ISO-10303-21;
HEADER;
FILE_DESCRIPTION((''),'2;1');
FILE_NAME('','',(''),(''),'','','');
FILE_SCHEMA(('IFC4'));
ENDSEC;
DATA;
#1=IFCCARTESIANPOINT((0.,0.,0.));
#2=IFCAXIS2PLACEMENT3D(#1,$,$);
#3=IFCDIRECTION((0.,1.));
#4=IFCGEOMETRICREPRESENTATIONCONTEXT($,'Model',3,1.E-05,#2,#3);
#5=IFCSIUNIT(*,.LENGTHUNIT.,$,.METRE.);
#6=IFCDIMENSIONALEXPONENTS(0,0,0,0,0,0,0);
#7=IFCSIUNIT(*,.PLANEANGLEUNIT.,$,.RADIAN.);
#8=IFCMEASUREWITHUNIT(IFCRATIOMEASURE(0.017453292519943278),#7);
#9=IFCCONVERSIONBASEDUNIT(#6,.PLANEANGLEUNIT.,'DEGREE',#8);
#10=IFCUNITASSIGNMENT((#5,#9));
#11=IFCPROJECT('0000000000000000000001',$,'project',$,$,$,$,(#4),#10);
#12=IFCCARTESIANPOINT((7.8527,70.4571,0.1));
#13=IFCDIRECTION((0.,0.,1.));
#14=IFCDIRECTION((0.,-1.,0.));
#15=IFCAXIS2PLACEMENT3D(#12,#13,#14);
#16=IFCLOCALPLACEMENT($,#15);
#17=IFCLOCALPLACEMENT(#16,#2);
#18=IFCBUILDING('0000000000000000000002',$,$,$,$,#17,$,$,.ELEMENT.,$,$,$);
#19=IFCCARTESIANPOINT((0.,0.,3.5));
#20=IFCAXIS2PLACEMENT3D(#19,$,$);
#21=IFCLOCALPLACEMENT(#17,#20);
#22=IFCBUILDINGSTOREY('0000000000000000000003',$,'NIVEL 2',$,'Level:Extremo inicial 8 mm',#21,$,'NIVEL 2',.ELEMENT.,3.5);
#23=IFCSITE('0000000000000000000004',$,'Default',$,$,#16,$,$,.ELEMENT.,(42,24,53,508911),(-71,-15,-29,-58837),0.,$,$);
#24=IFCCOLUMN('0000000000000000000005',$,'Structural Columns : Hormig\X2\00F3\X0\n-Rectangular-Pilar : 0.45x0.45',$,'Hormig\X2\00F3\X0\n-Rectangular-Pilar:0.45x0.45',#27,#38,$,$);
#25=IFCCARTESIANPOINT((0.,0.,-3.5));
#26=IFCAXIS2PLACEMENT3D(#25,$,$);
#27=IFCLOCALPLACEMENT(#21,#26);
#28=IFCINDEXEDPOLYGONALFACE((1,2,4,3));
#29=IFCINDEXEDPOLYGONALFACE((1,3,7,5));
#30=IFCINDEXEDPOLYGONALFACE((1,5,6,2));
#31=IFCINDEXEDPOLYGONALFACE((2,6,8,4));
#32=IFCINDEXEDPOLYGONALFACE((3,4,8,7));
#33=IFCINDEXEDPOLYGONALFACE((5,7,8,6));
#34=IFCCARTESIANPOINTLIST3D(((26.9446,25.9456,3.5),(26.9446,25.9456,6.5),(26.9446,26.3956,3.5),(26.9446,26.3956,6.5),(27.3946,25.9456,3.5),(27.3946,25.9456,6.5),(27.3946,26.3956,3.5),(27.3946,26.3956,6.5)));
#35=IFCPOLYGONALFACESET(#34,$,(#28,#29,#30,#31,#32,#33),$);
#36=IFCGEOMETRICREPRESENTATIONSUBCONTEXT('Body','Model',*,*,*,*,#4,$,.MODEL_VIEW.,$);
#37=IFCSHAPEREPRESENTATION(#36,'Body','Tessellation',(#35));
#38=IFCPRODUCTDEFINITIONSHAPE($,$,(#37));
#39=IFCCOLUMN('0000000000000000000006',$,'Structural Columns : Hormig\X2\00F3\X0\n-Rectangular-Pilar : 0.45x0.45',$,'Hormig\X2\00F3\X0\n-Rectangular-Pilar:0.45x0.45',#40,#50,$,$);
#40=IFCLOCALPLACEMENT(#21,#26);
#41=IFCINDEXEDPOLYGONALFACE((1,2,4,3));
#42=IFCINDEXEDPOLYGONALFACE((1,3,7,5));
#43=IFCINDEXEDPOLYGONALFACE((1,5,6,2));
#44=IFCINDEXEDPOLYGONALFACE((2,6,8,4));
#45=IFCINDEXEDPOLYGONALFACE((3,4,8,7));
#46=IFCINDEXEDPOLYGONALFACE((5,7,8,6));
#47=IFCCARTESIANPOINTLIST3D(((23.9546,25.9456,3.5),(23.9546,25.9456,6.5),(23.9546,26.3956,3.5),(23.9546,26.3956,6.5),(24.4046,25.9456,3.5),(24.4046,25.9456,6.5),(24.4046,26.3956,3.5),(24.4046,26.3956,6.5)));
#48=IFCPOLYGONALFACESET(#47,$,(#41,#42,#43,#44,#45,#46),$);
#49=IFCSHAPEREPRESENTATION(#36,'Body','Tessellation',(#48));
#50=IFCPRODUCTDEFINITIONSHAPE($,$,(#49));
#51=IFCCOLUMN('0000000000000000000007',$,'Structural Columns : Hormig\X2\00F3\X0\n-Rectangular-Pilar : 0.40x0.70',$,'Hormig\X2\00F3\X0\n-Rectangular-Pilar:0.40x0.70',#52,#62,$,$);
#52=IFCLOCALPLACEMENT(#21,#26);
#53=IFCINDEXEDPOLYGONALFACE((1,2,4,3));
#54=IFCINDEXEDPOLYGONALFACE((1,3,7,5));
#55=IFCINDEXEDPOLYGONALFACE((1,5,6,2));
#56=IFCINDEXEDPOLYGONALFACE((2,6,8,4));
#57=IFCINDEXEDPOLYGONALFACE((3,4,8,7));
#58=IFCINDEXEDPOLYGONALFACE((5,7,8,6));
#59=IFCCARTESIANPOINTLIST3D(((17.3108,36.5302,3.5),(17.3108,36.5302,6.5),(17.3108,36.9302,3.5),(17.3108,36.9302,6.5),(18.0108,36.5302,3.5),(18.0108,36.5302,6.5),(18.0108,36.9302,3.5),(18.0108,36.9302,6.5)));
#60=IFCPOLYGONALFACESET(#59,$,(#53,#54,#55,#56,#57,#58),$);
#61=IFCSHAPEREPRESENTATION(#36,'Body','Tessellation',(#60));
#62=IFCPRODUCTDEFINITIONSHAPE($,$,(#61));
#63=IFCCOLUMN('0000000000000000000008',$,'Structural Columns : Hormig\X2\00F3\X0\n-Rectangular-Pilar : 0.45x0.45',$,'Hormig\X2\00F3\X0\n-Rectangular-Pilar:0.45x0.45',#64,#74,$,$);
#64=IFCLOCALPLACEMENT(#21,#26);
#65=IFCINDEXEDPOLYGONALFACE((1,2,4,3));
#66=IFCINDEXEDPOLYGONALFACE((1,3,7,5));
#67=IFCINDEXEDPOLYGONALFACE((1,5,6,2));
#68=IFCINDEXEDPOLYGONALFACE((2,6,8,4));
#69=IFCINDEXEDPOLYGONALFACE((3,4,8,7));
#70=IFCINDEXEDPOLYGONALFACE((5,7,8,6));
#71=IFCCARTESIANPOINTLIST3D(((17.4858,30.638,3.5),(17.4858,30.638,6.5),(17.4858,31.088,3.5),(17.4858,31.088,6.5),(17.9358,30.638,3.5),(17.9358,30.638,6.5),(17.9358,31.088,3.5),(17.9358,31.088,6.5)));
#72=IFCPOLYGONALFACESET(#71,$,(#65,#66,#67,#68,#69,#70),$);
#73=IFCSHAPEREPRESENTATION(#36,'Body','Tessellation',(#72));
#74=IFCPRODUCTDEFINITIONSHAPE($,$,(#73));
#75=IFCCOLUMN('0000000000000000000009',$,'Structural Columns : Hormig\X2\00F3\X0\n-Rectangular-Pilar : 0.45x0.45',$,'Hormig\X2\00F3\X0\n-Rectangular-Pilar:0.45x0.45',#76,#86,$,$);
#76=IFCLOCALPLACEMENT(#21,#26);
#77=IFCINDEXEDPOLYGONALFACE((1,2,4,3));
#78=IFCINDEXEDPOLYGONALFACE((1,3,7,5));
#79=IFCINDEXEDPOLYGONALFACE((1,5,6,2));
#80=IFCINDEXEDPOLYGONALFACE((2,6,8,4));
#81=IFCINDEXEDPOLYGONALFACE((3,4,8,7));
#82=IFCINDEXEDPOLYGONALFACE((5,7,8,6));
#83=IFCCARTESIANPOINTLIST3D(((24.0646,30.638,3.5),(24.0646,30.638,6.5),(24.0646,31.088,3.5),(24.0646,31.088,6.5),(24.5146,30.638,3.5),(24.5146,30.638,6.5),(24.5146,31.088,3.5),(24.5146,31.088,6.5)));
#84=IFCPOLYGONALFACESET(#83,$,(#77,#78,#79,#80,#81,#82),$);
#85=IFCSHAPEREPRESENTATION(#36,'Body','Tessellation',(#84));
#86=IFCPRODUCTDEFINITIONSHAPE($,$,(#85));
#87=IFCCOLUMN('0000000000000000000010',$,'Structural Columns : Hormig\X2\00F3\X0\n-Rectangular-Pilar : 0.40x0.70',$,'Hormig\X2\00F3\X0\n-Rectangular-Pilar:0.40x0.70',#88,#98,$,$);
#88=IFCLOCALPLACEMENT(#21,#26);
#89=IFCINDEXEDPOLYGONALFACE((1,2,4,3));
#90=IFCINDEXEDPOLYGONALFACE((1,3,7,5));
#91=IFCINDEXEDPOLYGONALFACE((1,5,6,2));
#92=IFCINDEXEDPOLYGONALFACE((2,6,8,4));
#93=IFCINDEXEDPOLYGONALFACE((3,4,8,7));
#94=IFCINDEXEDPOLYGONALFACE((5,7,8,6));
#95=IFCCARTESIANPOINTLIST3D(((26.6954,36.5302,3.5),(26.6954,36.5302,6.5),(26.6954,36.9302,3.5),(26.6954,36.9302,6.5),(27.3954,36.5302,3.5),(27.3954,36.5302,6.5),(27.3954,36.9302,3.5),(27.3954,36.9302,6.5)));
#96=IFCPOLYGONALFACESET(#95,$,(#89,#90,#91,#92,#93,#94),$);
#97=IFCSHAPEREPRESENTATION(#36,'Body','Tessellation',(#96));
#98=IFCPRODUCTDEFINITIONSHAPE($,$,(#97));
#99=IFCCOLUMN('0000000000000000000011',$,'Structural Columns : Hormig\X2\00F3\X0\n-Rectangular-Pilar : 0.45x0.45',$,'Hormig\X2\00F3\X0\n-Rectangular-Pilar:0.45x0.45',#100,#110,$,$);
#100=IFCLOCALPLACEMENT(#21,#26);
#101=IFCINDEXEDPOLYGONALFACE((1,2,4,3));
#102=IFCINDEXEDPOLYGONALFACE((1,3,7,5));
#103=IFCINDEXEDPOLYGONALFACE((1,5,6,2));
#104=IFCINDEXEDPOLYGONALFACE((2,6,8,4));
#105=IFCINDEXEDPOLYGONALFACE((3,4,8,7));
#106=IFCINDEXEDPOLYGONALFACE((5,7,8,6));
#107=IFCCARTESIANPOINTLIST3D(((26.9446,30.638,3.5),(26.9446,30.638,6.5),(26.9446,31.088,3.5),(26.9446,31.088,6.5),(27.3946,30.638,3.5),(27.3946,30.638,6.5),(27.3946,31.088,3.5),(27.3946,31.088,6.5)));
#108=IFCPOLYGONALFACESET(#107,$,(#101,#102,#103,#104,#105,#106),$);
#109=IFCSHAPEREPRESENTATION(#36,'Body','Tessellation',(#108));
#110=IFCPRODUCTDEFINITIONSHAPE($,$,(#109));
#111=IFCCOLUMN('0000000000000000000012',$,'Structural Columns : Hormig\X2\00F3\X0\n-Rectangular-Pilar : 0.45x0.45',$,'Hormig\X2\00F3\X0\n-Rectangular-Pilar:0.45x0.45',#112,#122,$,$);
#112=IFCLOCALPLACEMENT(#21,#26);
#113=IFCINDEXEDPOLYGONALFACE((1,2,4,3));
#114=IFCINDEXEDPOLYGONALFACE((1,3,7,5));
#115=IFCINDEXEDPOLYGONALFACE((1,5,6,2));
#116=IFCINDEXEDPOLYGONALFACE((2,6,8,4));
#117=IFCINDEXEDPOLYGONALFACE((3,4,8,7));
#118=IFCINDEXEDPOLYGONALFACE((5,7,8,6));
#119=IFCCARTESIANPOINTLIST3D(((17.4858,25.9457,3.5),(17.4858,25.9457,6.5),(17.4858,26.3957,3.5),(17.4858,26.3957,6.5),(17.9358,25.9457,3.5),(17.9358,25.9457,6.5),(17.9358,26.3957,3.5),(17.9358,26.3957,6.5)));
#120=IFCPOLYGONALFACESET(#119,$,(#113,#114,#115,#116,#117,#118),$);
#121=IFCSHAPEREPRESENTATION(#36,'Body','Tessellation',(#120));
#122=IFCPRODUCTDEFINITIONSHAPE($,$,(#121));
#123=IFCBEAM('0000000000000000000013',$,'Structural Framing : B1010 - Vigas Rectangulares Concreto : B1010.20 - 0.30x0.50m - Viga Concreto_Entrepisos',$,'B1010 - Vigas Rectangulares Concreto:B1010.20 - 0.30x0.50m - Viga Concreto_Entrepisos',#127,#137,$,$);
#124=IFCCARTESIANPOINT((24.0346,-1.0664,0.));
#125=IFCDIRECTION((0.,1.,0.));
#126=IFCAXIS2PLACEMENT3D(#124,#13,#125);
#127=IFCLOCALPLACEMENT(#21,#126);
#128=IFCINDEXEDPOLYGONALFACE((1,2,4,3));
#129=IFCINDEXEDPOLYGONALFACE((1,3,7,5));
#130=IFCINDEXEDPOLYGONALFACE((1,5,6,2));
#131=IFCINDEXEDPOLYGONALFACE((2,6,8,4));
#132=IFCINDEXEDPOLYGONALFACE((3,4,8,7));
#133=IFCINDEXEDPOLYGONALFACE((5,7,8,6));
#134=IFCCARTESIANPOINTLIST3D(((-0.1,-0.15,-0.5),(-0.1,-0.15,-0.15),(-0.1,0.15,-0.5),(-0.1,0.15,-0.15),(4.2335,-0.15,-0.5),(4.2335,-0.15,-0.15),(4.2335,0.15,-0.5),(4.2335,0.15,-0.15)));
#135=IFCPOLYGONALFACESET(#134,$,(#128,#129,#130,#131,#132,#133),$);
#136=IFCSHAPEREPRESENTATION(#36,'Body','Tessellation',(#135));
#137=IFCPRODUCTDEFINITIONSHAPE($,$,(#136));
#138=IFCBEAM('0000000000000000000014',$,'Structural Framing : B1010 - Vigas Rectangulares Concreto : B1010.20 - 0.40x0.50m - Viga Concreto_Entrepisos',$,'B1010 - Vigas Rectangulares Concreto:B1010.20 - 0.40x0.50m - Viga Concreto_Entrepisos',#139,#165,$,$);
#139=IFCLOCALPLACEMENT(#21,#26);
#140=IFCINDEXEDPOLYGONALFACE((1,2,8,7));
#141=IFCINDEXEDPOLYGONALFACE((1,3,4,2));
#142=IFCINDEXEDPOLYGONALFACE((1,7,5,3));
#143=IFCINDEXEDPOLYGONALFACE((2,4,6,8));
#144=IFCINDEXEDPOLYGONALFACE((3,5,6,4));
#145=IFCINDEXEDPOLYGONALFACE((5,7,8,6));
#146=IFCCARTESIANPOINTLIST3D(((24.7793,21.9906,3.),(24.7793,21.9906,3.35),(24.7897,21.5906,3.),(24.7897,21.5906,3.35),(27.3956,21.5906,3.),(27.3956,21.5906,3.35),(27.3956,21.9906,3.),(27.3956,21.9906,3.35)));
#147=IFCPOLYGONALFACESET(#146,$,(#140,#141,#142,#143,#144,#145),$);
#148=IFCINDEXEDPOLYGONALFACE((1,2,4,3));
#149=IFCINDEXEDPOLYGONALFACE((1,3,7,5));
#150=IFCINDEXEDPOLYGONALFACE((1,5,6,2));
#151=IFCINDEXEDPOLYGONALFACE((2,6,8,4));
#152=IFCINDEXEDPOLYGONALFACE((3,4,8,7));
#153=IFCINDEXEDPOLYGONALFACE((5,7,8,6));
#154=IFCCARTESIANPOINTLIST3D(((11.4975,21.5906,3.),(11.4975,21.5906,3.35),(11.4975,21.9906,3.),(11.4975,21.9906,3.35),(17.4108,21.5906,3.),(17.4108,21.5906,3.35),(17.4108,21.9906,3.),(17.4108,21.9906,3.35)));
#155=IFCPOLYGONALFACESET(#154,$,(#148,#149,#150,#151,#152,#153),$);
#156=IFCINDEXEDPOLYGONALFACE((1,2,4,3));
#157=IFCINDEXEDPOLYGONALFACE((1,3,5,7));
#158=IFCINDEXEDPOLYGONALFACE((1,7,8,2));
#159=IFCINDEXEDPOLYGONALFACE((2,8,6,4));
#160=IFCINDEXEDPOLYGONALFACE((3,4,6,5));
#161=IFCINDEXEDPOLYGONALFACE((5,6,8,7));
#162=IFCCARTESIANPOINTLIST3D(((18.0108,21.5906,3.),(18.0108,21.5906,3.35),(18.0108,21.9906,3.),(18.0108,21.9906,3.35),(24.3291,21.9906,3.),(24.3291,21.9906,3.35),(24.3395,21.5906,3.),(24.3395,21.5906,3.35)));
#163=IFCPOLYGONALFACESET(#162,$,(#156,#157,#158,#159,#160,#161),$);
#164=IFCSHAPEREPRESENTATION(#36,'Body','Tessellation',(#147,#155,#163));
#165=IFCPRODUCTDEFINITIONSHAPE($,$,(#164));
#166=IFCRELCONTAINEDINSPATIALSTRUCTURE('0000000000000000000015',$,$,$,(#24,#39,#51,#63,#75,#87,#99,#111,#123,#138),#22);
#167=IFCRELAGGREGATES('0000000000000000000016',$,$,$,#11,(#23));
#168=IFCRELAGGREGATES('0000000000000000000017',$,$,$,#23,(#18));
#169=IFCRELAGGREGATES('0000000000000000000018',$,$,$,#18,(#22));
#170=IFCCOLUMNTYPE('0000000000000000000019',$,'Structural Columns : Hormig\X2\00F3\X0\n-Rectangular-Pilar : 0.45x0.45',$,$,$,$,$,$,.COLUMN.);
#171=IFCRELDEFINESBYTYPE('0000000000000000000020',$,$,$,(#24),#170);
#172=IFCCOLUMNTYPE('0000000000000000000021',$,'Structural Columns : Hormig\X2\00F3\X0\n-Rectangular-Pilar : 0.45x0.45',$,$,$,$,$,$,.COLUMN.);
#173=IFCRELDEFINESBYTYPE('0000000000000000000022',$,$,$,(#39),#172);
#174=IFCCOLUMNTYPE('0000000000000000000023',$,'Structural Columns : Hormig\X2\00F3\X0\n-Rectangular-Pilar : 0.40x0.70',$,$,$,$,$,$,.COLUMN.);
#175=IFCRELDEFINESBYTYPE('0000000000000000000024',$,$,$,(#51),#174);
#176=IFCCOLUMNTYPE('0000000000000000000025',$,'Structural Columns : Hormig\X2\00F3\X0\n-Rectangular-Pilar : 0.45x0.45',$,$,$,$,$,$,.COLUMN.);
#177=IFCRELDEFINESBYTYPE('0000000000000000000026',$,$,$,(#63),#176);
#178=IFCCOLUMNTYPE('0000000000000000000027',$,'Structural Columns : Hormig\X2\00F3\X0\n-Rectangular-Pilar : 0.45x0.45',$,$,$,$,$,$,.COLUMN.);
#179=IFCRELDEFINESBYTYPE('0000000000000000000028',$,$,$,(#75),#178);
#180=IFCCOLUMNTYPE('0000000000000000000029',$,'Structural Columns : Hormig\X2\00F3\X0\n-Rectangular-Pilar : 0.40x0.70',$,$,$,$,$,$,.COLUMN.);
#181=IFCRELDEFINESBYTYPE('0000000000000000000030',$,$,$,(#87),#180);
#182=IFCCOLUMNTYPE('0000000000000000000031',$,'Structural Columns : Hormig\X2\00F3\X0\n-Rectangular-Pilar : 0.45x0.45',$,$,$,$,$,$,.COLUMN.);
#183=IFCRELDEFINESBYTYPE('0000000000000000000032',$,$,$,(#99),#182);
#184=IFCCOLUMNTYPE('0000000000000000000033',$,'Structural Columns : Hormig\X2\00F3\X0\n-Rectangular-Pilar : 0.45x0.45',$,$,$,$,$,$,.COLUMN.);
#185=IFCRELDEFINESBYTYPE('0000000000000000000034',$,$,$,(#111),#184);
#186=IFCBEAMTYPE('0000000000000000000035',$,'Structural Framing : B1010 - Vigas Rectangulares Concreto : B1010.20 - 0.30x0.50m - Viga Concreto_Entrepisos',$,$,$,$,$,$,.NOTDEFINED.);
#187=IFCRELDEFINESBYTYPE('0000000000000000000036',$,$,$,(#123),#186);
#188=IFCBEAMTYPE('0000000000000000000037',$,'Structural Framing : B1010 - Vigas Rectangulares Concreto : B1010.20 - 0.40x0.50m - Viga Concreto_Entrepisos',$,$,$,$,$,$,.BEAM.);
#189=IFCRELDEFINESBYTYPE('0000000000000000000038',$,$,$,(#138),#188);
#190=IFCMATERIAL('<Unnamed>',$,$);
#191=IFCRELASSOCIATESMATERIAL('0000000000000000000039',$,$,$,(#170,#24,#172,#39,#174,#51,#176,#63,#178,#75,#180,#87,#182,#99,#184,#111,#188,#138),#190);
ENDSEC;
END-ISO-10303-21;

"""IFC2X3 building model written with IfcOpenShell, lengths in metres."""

from ifc_helpers import new_model, entity, si_unit, converted_unit, direction, frame, frame_2d, origin, origin_2d_with_axis, place, context, subcontext, project, spatial, rectangle, extrude, clip, halfspace, source, transform, mapped, material, type_object, type_shapes, element, save


model = new_model("IFC2X3")

# Units and contexts
model_context = context("Model", 3, precision=1e-05, world=origin(), true_north=direction((0.0, 1.0)))
body_context = subcontext(model_context, "Body", "Model", "MODEL_VIEW")
ifc_project = project(units=[si_unit("LENGTHUNIT", "METRE"), converted_unit("PLANEANGLEUNIT", "DEGREE", entity("IfcRatioMeasure", 0.017453292519943278), si_unit("PLANEANGLEUNIT", "RADIAN"), dimensions=[0, 0, 0, 0, 0, 0, 0])], contexts=[model_context])

# Site, building, storey
site_placement = place(None, frame((7.8527, 70.4571, 0.1), z_axis=(0.0, 0.0, 1.0), x_axis=(0.0, -1.0, 0.0)))
site = spatial("IfcSite", under=ifc_project, at=site_placement, Name="Default", CompositionType="ELEMENT", RefLatitude=(42, 24, 53, 508911), RefLongitude=(-71, -15, -29, -58837), RefElevation=0.0)
building_placement = place(site_placement, origin())
building = spatial("IfcBuilding", under=site, at=building_placement, CompositionType="ELEMENT")
storey_placement = place(building_placement, frame((0.0, 0.0, 3.5)))
storey = spatial("IfcBuildingStorey", under=building, at=storey_placement, Name="NIVEL 2", ObjectType="Level:Extremo inicial 8 mm", LongName="NIVEL 2", CompositionType="ELEMENT", Elevation=3.5)

# Columns
ifc_material_1 = material(Name="<Unnamed>")
column_type_1 = type_object("IfcColumnType", Name="Structural Columns : Hormigón-Rectangular-Pilar : 0.45x0.45", PredefinedType="COLUMN", material=ifc_material_1)
shared_shape_1 = source(origin(), body_context, "Body", "SweptSolid", [
    extrude(rectangle(XDim=0.45, YDim=0.45, at=origin_2d_with_axis()), frame((27.1696, 26.1706, 3.5), z_axis=(0.0, 0.0, 1.0), x_axis=(0.0, -1.0, 0.0)), (0.0, 0.0, 1.0), 3.0),
])
type_shapes(column_type_1, [shared_shape_1])
column_1_placement = place(storey_placement, frame((0.0, 0.0, -3.5)))
element("IfcColumn", 1, at=column_1_placement, inside=storey, type_object=column_type_1, material=ifc_material_1, Name="Structural Columns : Hormigón-Rectangular-Pilar : 0.45x0.45", ObjectType="Hormigón-Rectangular-Pilar:0.45x0.45", context=body_context, shape_type="MappedRepresentation", body=[
    mapped(shared_shape_1, transform((0.0, 0.0, 0.0), scale=1.0)),
])
column_type_2 = type_object("IfcColumnType", Name="Structural Columns : Hormigón-Rectangular-Pilar : 0.45x0.45", PredefinedType="COLUMN", material=ifc_material_1)
shared_shape_2 = source(origin(), body_context, "Body", "SweptSolid", [
    extrude(rectangle(XDim=0.45, YDim=0.45, at=origin_2d_with_axis()), frame((24.1796, 26.1706, 3.5), z_axis=(0.0, 0.0, 1.0), x_axis=(0.0, -1.0, 0.0)), (0.0, 0.0, 1.0), 3.0),
])
type_shapes(column_type_2, [shared_shape_2])
column_2_placement = place(storey_placement, frame((0.0, 0.0, -3.5)))
element("IfcColumn", 2, at=column_2_placement, inside=storey, type_object=column_type_2, material=ifc_material_1, Name="Structural Columns : Hormigón-Rectangular-Pilar : 0.45x0.45", ObjectType="Hormigón-Rectangular-Pilar:0.45x0.45", context=body_context, shape_type="MappedRepresentation", body=[
    mapped(shared_shape_2, transform((0.0, 0.0, 0.0), scale=1.0)),
])
column_type_3 = type_object("IfcColumnType", Name="Structural Columns : Hormigón-Rectangular-Pilar : 0.40x0.70", PredefinedType="COLUMN", material=ifc_material_1)
shared_shape_3 = source(origin(), body_context, "Body", "SweptSolid", [
    extrude(rectangle(XDim=0.4, YDim=0.7, at=frame_2d((0.0, 0.0), x_axis=(1.0, 0.0))), frame((17.6608, 36.7302, 3.5), z_axis=(0.0, 0.0, 1.0), x_axis=(0.0, -1.0, 0.0)), (0.0, 0.0, 1.0), 3.0),
])
type_shapes(column_type_3, [shared_shape_3])
column_3_placement = place(storey_placement, frame((0.0, 0.0, -3.5)))
element("IfcColumn", 3, at=column_3_placement, inside=storey, type_object=column_type_3, material=ifc_material_1, Name="Structural Columns : Hormigón-Rectangular-Pilar : 0.40x0.70", ObjectType="Hormigón-Rectangular-Pilar:0.40x0.70", context=body_context, shape_type="MappedRepresentation", body=[
    mapped(shared_shape_3, transform((0.0, 0.0, 0.0), scale=1.0)),
])
column_type_4 = type_object("IfcColumnType", Name="Structural Columns : Hormigón-Rectangular-Pilar : 0.45x0.45", PredefinedType="COLUMN", material=ifc_material_1)
shared_shape_4 = source(origin(), body_context, "Body", "SweptSolid", [
    extrude(rectangle(XDim=0.45, YDim=0.45, at=origin_2d_with_axis()), frame((17.7108, 30.863, 3.5), z_axis=(0.0, 0.0, 1.0), x_axis=(0.0, -1.0, 0.0)), (0.0, 0.0, 1.0), 3.0),
])
type_shapes(column_type_4, [shared_shape_4])
column_4_placement = place(storey_placement, frame((0.0, 0.0, -3.5)))
element("IfcColumn", 4, at=column_4_placement, inside=storey, type_object=column_type_4, material=ifc_material_1, Name="Structural Columns : Hormigón-Rectangular-Pilar : 0.45x0.45", ObjectType="Hormigón-Rectangular-Pilar:0.45x0.45", context=body_context, shape_type="MappedRepresentation", body=[
    mapped(shared_shape_4, transform((0.0, 0.0, 0.0), scale=1.0)),
])
column_type_5 = type_object("IfcColumnType", Name="Structural Columns : Hormigón-Rectangular-Pilar : 0.45x0.45", PredefinedType="COLUMN", material=ifc_material_1)
shared_shape_5 = source(origin(), body_context, "Body", "SweptSolid", [
    extrude(rectangle(XDim=0.45, YDim=0.45, at=origin_2d_with_axis()), frame((24.2896, 30.863, 3.5), z_axis=(0.0, 0.0, 1.0), x_axis=(0.0, -1.0, 0.0)), (0.0, 0.0, 1.0), 3.0),
])
type_shapes(column_type_5, [shared_shape_5])
column_5_placement = place(storey_placement, frame((0.0, 0.0, -3.5)))
element("IfcColumn", 5, at=column_5_placement, inside=storey, type_object=column_type_5, material=ifc_material_1, Name="Structural Columns : Hormigón-Rectangular-Pilar : 0.45x0.45", ObjectType="Hormigón-Rectangular-Pilar:0.45x0.45", context=body_context, shape_type="MappedRepresentation", body=[
    mapped(shared_shape_5, transform((0.0, 0.0, 0.0), scale=1.0)),
])
column_type_6 = type_object("IfcColumnType", Name="Structural Columns : Hormigón-Rectangular-Pilar : 0.40x0.70", PredefinedType="COLUMN", material=ifc_material_1)
shared_shape_6 = source(origin(), body_context, "Body", "SweptSolid", [
    extrude(rectangle(XDim=0.4, YDim=0.7, at=frame_2d((0.0, 0.0), x_axis=(1.0, 0.0))), frame((27.0454, 36.7302, 3.5), z_axis=(0.0, 0.0, 1.0), x_axis=(0.0, -1.0, 0.0)), (0.0, 0.0, 1.0), 3.0),
])
type_shapes(column_type_6, [shared_shape_6])
column_6_placement = place(storey_placement, frame((0.0, 0.0, -3.5)))
element("IfcColumn", 6, at=column_6_placement, inside=storey, type_object=column_type_6, material=ifc_material_1, Name="Structural Columns : Hormigón-Rectangular-Pilar : 0.40x0.70", ObjectType="Hormigón-Rectangular-Pilar:0.40x0.70", context=body_context, shape_type="MappedRepresentation", body=[
    mapped(shared_shape_6, transform((0.0, 0.0, 0.0), scale=1.0)),
])
column_type_7 = type_object("IfcColumnType", Name="Structural Columns : Hormigón-Rectangular-Pilar : 0.45x0.45", PredefinedType="COLUMN", material=ifc_material_1)
shared_shape_7 = source(origin(), body_context, "Body", "SweptSolid", [
    extrude(rectangle(XDim=0.45, YDim=0.45, at=origin_2d_with_axis()), frame((27.1696, 30.863, 3.5), z_axis=(0.0, 0.0, 1.0), x_axis=(0.0, -1.0, 0.0)), (0.0, 0.0, 1.0), 3.0),
])
type_shapes(column_type_7, [shared_shape_7])
column_7_placement = place(storey_placement, frame((0.0, 0.0, -3.5)))
element("IfcColumn", 7, at=column_7_placement, inside=storey, type_object=column_type_7, material=ifc_material_1, Name="Structural Columns : Hormigón-Rectangular-Pilar : 0.45x0.45", ObjectType="Hormigón-Rectangular-Pilar:0.45x0.45", context=body_context, shape_type="MappedRepresentation", body=[
    mapped(shared_shape_7, transform((0.0, 0.0, 0.0), scale=1.0)),
])
column_type_8 = type_object("IfcColumnType", Name="Structural Columns : Hormigón-Rectangular-Pilar : 0.45x0.45", PredefinedType="COLUMN", material=ifc_material_1)
shared_shape_8 = source(origin(), body_context, "Body", "SweptSolid", [
    extrude(rectangle(XDim=0.45, YDim=0.45, at=origin_2d_with_axis()), frame((17.7108, 26.1707, 3.5), z_axis=(0.0, 0.0, 1.0), x_axis=(0.0, -1.0, 0.0)), (0.0, 0.0, 1.0), 3.0),
])
type_shapes(column_type_8, [shared_shape_8])
column_8_placement = place(storey_placement, frame((0.0, 0.0, -3.5)))
element("IfcColumn", 8, at=column_8_placement, inside=storey, type_object=column_type_8, material=ifc_material_1, Name="Structural Columns : Hormigón-Rectangular-Pilar : 0.45x0.45", ObjectType="Hormigón-Rectangular-Pilar:0.45x0.45", context=body_context, shape_type="MappedRepresentation", body=[
    mapped(shared_shape_8, transform((0.0, 0.0, 0.0), scale=1.0)),
])

# Beams
beam_type_1 = type_object("IfcBeamType", Name="Structural Framing : B1010 - Vigas Rectangulares Concreto : B1010.20 - 0.30x0.50m - Viga Concreto_Entrepisos", PredefinedType="NOTDEFINED")
beam_1_placement = place(storey_placement, frame((24.0346, -1.0664, 0.0), z_axis=(0.0, 0.0, 1.0), x_axis=(0.0, 1.0, 0.0)))
element("IfcBeam", 9, at=beam_1_placement, inside=storey, type_object=beam_type_1, Name="Structural Framing : B1010 - Vigas Rectangulares Concreto : B1010.20 - 0.30x0.50m - Viga Concreto_Entrepisos", ObjectType="B1010 - Vigas Rectangulares Concreto:B1010.20 - 0.30x0.50m - Viga Concreto_Entrepisos", context=body_context, shape_type="SweptSolid", body=[
    extrude(rectangle(XDim=0.35, YDim=0.3, at=frame_2d((0.0, 0.0), x_axis=(1.0, 0.0))), frame((-0.1, 0.0, -0.325), z_axis=(1.0, 0.0, 0.0), x_axis=(0.0, 0.0, -1.0)), (0.0, 0.0, 1.0), 4.3335),
])
beam_type_2 = type_object("IfcBeamType", Name="Structural Framing : B1010 - Vigas Rectangulares Concreto : B1010.20 - 0.40x0.50m - Viga Concreto_Entrepisos", PredefinedType="BEAM", material=ifc_material_1)
shared_shape_9 = source(origin(), body_context, "Body", "SweptSolid", [
    clip(extrude(rectangle(XDim=0.35, YDim=0.4, at=origin_2d_with_axis()), frame((24.7793, 21.7906, 3.175), z_axis=(1.0, 0.0, 0.0), x_axis=(0.0, 0.0, -1.0)), (0.0, 0.0, 1.0), 2.6163), halfspace(frame((24.6959, 25.1935, 3.5), z_axis=(-0.999661, -0.026022, 0.0), x_axis=(0.026022, -0.999661, 0.0)), False)),
    extrude(rectangle(XDim=0.35, YDim=0.4, at=frame_2d((0.0, 0.0), x_axis=(1.0, 0.0))), frame((11.4975, 21.7906, 3.175), z_axis=(1.0, 0.0, 0.0), x_axis=(0.0, 0.0, -1.0)), (0.0, 0.0, 1.0), 5.9133),
    clip(extrude(rectangle(XDim=0.35, YDim=0.4, at=frame_2d((0.0, 0.0), x_axis=(1.0, 0.0))), frame((18.0108, 21.7906, 3.175), z_axis=(1.0, 0.0, 0.0), x_axis=(0.0, 0.0, -1.0)), (0.0, 0.0, 1.0), 6.3287), halfspace(frame((24.246, 25.1818, 3.0), z_axis=(0.999661, 0.026022, 0.0), x_axis=(0.026022, -0.999661, 0.0)), False)),
])
type_shapes(beam_type_2, [shared_shape_9])
beam_2_placement = place(storey_placement, frame((0.0, 0.0, -3.5)))
element("IfcBeam", 10, at=beam_2_placement, inside=storey, type_object=beam_type_2, material=ifc_material_1, Name="Structural Framing : B1010 - Vigas Rectangulares Concreto : B1010.20 - 0.40x0.50m - Viga Concreto_Entrepisos", ObjectType="B1010 - Vigas Rectangulares Concreto:B1010.20 - 0.40x0.50m - Viga Concreto_Entrepisos", context=body_context, shape_type="MappedRepresentation", body=[
    mapped(shared_shape_9, transform((0.0, 0.0, 0.0), scale=1.0)),
])

save(model, "model.ifc")
